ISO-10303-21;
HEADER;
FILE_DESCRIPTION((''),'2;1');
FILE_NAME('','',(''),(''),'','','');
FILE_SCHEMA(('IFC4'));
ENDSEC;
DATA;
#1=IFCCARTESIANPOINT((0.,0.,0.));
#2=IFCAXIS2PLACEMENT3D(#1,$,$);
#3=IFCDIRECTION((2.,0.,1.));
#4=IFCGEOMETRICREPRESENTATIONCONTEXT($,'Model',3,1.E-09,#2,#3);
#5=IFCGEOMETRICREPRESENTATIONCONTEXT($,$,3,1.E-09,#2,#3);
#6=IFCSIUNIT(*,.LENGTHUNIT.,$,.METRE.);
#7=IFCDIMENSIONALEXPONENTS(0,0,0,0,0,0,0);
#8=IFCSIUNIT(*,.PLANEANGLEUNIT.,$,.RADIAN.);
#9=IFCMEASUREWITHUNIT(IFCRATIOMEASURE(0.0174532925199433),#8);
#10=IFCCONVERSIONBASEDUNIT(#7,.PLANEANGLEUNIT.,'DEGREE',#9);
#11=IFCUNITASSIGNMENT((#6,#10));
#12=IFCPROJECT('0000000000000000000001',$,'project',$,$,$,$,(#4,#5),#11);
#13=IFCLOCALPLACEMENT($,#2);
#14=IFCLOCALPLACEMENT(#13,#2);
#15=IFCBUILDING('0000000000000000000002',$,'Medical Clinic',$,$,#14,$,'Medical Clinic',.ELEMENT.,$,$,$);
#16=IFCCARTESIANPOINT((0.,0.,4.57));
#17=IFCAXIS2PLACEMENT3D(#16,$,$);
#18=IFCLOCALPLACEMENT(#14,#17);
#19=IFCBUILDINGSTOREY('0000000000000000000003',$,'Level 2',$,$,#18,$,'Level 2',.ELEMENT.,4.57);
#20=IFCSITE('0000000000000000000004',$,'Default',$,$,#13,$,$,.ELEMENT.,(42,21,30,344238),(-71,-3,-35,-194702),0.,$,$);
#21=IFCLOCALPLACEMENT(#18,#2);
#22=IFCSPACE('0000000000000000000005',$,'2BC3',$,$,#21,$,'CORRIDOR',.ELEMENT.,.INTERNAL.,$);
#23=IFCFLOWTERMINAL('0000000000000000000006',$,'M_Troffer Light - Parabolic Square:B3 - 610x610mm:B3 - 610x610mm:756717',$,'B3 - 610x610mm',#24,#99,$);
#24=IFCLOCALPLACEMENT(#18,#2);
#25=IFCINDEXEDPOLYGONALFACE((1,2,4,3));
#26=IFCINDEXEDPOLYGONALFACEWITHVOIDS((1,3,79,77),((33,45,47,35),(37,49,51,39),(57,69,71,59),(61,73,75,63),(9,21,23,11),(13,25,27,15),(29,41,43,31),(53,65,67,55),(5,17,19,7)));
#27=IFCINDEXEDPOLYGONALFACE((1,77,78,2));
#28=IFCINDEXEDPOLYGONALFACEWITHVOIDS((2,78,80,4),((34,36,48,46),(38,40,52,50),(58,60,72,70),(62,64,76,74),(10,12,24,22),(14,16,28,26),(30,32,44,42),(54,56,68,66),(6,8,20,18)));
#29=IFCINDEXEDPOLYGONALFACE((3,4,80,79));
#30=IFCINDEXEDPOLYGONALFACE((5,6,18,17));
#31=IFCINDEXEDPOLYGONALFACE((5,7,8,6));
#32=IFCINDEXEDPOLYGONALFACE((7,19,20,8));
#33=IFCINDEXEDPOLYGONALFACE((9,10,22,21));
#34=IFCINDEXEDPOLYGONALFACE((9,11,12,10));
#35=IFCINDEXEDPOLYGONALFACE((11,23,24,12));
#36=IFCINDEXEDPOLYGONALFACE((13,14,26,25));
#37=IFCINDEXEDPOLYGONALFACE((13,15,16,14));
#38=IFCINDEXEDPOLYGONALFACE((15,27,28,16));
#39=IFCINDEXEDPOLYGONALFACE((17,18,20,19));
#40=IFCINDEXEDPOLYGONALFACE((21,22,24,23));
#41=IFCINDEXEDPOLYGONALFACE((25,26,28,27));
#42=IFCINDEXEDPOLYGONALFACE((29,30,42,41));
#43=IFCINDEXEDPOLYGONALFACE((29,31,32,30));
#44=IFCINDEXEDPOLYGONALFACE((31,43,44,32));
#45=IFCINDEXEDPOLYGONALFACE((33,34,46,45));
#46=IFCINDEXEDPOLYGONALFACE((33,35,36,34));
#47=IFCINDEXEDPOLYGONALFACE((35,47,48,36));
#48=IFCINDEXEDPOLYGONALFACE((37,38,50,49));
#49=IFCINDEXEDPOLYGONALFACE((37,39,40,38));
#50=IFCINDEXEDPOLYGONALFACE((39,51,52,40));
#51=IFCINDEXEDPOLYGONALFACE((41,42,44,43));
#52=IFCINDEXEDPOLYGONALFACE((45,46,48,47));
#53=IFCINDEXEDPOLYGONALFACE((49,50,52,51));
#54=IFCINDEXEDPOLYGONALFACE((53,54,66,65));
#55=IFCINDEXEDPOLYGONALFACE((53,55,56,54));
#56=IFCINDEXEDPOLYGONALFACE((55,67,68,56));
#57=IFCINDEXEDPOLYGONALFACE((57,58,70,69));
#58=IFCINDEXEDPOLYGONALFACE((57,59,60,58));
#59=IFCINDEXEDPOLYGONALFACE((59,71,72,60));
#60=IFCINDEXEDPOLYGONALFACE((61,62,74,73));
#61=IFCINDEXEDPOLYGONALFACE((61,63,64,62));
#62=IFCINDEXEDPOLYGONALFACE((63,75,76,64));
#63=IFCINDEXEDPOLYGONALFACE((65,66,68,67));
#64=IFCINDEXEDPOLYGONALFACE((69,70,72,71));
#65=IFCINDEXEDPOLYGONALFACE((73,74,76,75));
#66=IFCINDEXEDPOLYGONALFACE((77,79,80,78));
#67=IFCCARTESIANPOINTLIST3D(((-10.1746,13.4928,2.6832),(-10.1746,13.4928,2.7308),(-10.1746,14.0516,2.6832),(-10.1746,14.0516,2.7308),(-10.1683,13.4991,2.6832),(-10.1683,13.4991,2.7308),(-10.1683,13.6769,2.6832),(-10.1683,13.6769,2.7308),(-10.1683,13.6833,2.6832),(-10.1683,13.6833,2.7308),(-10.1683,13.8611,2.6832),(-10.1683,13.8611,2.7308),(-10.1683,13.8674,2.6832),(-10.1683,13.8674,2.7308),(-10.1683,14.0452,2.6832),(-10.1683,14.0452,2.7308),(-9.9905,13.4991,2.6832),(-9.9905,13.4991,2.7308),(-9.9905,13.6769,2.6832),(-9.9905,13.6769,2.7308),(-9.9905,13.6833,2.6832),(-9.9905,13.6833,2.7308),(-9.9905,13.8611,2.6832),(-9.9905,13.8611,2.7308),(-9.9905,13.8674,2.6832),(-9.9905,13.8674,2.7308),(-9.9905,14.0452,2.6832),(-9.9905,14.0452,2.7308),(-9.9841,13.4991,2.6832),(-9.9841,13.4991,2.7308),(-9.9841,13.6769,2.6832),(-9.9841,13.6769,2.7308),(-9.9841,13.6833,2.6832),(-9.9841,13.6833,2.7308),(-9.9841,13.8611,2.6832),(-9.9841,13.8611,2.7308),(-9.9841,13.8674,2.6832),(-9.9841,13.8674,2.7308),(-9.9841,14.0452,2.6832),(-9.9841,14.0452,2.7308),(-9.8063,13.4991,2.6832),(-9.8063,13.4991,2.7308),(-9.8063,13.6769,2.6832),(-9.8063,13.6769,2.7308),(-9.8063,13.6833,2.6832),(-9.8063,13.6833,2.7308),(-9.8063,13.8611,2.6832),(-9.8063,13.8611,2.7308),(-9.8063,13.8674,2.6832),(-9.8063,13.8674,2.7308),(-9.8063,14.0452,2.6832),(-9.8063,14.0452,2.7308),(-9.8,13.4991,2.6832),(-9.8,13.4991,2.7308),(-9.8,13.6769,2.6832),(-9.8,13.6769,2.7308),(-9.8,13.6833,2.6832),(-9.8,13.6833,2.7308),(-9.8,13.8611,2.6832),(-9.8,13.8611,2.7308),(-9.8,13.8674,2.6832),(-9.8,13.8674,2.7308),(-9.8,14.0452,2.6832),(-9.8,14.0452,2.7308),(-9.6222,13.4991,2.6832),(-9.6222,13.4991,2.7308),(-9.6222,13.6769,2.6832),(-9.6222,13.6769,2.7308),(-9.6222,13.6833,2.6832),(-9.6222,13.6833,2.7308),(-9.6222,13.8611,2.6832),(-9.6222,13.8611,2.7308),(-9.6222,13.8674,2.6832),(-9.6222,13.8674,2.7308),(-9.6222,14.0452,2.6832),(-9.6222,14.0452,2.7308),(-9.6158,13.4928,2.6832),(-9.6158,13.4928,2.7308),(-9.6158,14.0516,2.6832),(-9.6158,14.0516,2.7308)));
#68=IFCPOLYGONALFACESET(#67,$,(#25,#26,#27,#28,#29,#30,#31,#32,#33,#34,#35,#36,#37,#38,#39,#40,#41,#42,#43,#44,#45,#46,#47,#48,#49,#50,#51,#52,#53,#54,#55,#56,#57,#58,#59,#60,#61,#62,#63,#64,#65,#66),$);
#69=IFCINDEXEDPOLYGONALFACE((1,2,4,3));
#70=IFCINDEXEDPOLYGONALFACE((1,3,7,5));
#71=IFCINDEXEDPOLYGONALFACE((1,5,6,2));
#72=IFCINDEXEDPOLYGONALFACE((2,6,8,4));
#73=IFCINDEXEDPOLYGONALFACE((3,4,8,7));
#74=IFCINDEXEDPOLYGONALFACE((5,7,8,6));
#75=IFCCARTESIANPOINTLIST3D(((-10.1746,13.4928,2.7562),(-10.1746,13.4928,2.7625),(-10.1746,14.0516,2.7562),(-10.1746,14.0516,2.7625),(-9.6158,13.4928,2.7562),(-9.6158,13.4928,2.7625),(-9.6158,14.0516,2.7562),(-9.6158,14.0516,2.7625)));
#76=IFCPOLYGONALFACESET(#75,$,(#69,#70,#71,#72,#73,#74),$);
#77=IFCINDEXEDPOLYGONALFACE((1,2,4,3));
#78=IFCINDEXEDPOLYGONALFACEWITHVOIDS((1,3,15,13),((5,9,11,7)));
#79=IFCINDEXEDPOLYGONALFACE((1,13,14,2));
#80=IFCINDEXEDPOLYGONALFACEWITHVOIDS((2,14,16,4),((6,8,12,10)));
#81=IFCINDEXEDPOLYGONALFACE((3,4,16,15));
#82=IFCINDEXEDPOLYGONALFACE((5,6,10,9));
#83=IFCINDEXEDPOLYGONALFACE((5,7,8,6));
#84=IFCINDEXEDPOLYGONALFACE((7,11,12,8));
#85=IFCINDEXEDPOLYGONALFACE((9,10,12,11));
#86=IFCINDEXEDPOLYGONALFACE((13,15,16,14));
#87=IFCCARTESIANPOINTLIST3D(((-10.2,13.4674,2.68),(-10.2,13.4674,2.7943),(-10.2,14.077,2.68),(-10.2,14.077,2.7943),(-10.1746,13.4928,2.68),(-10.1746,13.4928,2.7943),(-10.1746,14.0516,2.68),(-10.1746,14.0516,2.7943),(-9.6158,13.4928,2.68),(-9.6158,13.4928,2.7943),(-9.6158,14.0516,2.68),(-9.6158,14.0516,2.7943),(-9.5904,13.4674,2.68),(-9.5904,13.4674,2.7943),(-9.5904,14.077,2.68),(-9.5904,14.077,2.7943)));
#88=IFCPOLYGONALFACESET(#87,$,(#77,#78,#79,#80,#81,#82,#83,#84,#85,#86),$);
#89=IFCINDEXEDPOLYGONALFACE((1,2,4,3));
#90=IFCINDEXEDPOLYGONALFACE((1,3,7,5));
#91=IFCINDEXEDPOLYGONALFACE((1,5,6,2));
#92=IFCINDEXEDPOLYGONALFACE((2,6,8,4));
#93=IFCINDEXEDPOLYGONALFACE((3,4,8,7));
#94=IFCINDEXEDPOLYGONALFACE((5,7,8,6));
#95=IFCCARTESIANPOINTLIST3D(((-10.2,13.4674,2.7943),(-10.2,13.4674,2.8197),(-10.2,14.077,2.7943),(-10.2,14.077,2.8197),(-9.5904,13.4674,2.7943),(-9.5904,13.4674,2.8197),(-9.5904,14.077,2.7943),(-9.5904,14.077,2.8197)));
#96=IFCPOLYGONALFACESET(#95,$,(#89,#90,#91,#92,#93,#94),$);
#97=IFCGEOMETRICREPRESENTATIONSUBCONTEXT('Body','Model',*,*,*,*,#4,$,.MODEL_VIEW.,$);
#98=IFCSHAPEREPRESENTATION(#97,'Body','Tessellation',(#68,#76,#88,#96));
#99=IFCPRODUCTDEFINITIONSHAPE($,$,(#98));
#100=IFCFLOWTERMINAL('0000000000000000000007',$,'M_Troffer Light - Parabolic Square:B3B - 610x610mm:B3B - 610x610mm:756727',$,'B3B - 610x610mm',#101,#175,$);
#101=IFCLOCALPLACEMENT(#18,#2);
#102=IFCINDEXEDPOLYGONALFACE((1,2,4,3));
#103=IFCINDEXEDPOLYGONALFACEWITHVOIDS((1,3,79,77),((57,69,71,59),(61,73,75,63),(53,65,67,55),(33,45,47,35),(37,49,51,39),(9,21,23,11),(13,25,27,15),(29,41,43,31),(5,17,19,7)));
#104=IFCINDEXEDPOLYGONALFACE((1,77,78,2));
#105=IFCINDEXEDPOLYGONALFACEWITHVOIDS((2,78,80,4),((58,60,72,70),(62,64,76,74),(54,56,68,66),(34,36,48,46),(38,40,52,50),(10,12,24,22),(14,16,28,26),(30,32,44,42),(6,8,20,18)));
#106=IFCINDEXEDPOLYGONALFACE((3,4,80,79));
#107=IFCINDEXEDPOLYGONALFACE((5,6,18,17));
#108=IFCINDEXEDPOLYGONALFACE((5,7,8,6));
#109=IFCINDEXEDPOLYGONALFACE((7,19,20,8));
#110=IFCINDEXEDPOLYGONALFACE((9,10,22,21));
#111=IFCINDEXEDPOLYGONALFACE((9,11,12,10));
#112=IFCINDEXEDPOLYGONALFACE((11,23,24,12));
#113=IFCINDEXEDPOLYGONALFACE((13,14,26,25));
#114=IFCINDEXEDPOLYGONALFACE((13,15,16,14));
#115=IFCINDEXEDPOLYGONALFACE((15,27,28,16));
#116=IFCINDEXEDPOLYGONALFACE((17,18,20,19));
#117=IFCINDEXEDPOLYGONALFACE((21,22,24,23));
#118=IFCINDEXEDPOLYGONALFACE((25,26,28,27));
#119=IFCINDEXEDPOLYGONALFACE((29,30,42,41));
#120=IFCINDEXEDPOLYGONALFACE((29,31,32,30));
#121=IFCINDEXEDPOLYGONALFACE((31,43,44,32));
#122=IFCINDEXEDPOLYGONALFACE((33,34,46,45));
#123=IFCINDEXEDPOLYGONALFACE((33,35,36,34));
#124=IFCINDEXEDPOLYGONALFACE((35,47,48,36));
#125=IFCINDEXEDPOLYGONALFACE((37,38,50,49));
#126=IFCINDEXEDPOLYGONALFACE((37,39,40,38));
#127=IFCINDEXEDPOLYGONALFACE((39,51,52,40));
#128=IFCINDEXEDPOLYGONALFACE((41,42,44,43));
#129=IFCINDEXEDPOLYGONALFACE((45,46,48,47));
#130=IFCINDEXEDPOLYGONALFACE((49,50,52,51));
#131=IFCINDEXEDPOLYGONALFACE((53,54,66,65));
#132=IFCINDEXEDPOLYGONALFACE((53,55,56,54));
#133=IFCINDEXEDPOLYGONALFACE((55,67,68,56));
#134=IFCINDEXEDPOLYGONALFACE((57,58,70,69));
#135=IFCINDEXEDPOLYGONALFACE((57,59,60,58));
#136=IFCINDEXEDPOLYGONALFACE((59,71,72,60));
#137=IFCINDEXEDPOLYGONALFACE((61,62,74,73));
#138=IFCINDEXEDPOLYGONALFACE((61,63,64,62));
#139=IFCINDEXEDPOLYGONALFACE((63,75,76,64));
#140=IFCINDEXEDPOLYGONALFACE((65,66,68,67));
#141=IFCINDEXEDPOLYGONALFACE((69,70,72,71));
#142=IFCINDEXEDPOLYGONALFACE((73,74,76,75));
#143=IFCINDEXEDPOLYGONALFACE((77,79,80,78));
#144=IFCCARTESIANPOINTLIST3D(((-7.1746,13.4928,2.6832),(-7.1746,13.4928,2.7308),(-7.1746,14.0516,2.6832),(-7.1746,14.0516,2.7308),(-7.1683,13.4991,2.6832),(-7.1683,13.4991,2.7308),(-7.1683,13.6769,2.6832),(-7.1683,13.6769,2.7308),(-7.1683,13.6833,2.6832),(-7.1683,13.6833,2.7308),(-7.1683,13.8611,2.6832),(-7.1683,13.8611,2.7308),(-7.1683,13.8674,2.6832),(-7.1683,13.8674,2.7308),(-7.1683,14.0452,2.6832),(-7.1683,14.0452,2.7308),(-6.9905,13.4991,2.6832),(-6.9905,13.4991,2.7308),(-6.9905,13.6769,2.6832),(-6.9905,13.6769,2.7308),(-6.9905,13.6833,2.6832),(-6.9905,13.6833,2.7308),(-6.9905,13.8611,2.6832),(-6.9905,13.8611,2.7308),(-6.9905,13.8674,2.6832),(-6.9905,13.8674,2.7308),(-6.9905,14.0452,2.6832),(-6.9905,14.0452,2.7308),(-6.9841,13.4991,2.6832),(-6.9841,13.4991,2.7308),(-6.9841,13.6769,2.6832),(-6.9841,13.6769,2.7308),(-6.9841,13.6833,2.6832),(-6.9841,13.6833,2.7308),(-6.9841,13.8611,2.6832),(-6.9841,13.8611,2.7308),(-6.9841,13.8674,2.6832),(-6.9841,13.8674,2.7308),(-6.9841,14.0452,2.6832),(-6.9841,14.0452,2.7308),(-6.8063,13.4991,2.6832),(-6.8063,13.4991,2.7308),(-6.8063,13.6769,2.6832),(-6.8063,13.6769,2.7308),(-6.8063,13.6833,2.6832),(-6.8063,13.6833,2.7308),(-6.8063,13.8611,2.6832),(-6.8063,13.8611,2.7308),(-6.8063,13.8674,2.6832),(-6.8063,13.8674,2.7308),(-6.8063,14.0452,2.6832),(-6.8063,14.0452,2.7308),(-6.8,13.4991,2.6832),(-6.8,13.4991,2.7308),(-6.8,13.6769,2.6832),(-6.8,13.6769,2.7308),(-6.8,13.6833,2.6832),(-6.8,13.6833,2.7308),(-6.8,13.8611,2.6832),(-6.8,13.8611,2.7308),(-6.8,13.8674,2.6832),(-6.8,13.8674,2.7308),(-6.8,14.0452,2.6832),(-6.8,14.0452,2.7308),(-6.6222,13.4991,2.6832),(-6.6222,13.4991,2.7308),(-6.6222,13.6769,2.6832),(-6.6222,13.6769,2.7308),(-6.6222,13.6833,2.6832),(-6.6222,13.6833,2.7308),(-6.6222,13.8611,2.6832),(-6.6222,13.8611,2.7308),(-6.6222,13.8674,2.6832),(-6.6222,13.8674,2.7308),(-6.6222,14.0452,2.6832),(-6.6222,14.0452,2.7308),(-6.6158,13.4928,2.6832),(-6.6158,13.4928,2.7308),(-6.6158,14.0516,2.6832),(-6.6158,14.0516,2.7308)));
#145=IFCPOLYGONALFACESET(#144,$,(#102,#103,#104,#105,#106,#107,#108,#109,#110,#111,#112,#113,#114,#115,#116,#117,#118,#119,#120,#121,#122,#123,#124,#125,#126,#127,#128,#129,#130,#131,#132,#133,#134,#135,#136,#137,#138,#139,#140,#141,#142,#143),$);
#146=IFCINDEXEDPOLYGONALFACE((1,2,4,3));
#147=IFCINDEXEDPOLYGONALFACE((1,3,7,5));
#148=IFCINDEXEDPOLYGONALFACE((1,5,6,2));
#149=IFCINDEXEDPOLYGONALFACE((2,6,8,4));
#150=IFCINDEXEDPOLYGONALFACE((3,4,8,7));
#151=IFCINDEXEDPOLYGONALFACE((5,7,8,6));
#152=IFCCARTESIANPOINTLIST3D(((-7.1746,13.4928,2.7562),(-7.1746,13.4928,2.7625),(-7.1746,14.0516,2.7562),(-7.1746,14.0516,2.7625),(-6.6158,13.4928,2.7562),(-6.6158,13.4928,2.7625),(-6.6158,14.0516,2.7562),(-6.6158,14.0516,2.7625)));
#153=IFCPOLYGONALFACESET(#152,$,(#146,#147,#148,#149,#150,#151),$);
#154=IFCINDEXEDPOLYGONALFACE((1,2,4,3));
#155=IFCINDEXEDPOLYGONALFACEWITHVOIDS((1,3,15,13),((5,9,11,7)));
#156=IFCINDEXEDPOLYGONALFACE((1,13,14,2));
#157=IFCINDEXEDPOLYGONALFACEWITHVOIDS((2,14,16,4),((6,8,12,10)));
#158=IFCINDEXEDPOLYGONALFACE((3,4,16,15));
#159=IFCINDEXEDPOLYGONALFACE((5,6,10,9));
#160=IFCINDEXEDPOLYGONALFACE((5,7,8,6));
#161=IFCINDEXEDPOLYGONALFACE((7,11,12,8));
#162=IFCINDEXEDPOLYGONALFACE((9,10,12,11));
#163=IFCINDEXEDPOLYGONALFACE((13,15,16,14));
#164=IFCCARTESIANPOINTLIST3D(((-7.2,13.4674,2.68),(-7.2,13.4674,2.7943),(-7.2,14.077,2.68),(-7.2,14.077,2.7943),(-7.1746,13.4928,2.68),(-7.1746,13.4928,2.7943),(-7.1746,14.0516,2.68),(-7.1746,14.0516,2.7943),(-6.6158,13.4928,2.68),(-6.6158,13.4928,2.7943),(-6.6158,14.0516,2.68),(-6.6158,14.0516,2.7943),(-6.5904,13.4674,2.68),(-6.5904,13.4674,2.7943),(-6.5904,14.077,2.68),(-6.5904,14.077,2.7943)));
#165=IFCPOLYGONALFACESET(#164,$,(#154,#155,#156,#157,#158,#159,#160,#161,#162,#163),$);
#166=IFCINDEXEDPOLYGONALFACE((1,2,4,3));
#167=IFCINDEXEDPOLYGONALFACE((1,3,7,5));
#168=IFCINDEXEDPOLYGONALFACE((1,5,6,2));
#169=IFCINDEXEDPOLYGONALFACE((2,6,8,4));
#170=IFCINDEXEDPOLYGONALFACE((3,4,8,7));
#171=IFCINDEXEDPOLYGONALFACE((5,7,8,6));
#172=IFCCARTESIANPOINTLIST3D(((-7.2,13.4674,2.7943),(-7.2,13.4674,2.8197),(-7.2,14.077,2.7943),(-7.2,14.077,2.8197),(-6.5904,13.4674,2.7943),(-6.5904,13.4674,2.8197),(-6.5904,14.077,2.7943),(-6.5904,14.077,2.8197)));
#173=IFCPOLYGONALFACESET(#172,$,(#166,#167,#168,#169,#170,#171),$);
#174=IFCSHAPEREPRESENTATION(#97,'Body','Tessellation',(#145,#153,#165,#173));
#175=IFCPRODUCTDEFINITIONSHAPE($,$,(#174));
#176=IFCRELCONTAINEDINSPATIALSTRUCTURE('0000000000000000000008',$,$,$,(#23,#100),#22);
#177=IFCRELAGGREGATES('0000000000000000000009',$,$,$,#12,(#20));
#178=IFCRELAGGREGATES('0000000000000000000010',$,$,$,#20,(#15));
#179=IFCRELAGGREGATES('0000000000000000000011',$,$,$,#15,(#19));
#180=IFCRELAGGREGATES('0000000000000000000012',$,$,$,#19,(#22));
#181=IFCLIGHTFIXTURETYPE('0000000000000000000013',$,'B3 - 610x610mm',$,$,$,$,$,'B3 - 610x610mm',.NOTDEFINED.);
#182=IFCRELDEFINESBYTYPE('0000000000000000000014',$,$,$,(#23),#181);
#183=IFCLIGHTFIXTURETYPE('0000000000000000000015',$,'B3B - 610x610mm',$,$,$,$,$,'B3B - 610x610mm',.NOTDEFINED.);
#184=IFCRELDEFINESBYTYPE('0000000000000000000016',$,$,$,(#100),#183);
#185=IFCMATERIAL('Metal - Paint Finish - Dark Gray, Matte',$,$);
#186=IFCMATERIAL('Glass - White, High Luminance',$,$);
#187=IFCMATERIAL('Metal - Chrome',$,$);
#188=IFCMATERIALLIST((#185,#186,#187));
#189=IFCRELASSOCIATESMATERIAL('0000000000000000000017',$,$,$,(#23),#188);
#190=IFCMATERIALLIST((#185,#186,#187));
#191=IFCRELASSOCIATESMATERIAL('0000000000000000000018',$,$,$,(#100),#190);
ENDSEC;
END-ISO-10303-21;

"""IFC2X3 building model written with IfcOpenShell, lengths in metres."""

from ifc_helpers import new_model, entity, si_unit, converted_unit, direction, frame, origin, origin_2d_with_axis, place, context, subcontext, project, spatial, polyline, rectangle, outline, extrude, source, transform, mapped, material, material_list, type_object, type_shapes, element, save


model = new_model("IFC2X3")

# Units and contexts
model_context = context("Model", 3, precision=1e-09, world=origin(), true_north=direction((2.0, 0.0, 1.0)))
context_of_model = context(None, 3, precision=1e-09, world=origin(), true_north=direction((2.0, 0.0, 1.0)))
body_context = subcontext(model_context, "Body", "Model", "MODEL_VIEW")
ifc_project = project(units=[si_unit("LENGTHUNIT", "METRE"), converted_unit("PLANEANGLEUNIT", "DEGREE", entity("IfcRatioMeasure", 0.0174532925199433), si_unit("PLANEANGLEUNIT", "RADIAN"), dimensions=[0, 0, 0, 0, 0, 0, 0])], contexts=[model_context, context_of_model])

# Site, building, storey, space
site_placement = place(None, origin())
site = spatial("IfcSite", under=ifc_project, at=site_placement, Name="Default", CompositionType="ELEMENT", RefLatitude=(42, 21, 30, 344238), RefLongitude=(-71, -3, -35, -194702), RefElevation=0.0)
building_placement = place(site_placement, origin())
building = spatial("IfcBuilding", under=site, at=building_placement, Name="Medical Clinic", LongName="Medical Clinic", CompositionType="ELEMENT")
storey_placement = place(building_placement, frame((0.0, 0.0, 4.57)))
storey = spatial("IfcBuildingStorey", under=building, at=storey_placement, Name="Level 2", LongName="Level 2", CompositionType="ELEMENT", Elevation=4.57)
space_1_placement = place(storey_placement, origin())
space_1 = spatial("IfcSpace", under=storey, at=space_1_placement, Name="2BC3", LongName="CORRIDOR", CompositionType="ELEMENT", InteriorOrExteriorSpace="INTERNAL")

# Flow terminals
ifc_material_1 = material(Name="Metal - Paint Finish - Dark Gray, Matte")
ifc_material_2 = material(Name="Glass - White, High Luminance")
ifc_material_3 = material(Name="Metal - Chrome")
ifc_material_list_1 = material_list([ifc_material_1, ifc_material_2, ifc_material_3])
light_fixture_type_1 = type_object("IfcLightFixtureType", Name="B3 - 610x610mm", ElementType="B3 - 610x610mm", PredefinedType="NOTDEFINED")
shared_shape_1 = source(origin(), body_context, "Body", "SweptSolid", [
    extrude(outline(polyline([(-0.2794, -0.2794), (0.2794, -0.2794), (0.2794, 0.2794), (-0.2794, 0.2794), (-0.2794, -0.2794)]), holes=[polyline([(-0.0952, 0.0953), (-0.273, 0.0953), (-0.273, 0.2731), (-0.0952, 0.2731), (-0.0952, 0.0953)]), polyline([(0.2731, 0.0953), (0.0953, 0.0953), (0.0953, 0.2731), (0.2731, 0.2731), (0.2731, 0.0953)]), polyline([(-0.0889, 0.2731), (0.0889, 0.2731), (0.0889, 0.0953), (-0.0889, 0.0953), (-0.0889, 0.2731)]), polyline([(0.2731, -0.273), (0.0953, -0.273), (0.0953, -0.0952), (0.2731, -0.0952), (0.2731, -0.273)]), polyline([(0.0889, -0.273), (-0.0889, -0.273), (-0.0889, -0.0952), (0.0889, -0.0952), (0.0889, -0.273)]), polyline([(-0.0952, -0.273), (-0.273, -0.273), (-0.273, -0.0952), (-0.0952, -0.0952), (-0.0952, -0.273)]), polyline([(-0.0952, -0.0889), (-0.273, -0.0889), (-0.273, 0.0889), (-0.0952, 0.0889), (-0.0952, -0.0889)]), polyline([(0.0889, -0.0889), (-0.0889, -0.0889), (-0.0889, 0.0889), (0.0889, 0.0889), (0.0889, -0.0889)]), polyline([(0.2731, -0.0889), (0.0953, -0.0889), (0.0953, 0.0889), (0.2731, 0.0889), (0.2731, -0.0889)])]), frame((0.0, -0.3048, -0.0508), z_axis=(0.0, 0.0, 1.0), x_axis=(-1.0, 0.0, 0.0)), (0.0, 0.0, 1.0), 0.0476),
    extrude(rectangle(XDim=0.5588, YDim=0.5588, at=origin_2d_with_axis()), frame((0.0, -0.3048, -0.0825), z_axis=(0.0, 0.0, 1.0), x_axis=(-1.0, 0.0, 0.0)), (0.0, 0.0, 1.0), 0.0064),
    extrude(outline(polyline([(-0.3048, -0.3048), (0.3048, -0.3048), (0.3048, 0.3048), (-0.3048, 0.3048), (-0.3048, -0.3048)]), holes=[polyline([(0.2794, 0.2794), (0.2794, -0.2794), (-0.2794, -0.2794), (-0.2794, 0.2794), (0.2794, 0.2794)])]), frame((0.0, -0.3048, -0.1143)), (0.0, 0.0, 1.0), 0.1143),
    extrude(rectangle(XDim=0.6096, YDim=0.6096, at=origin_2d_with_axis()), frame((0.0, -0.3048, -0.1397), z_axis=(0.0, 0.0, 1.0), x_axis=(-1.0, 0.0, 0.0)), (0.0, 0.0, 1.0), 0.0254),
])
type_shapes(light_fixture_type_1, [shared_shape_1])
flow_terminal_1_placement = place(space_1_placement, frame((-9.8952, 13.4674, 2.68), z_axis=(0.0, 0.0, -1.0), x_axis=(1.0, 0.0, 0.0)))
element("IfcFlowTerminal", 1, at=flow_terminal_1_placement, inside=space_1, type_object=light_fixture_type_1, material=ifc_material_list_1, Name="M_Troffer Light - Parabolic Square:B3 - 610x610mm:B3 - 610x610mm:756717", ObjectType="B3 - 610x610mm", context=body_context, shape_type="MappedRepresentation", body=[
    mapped(shared_shape_1, transform((0.0, 0.0, 0.0), scale=1.0)),
])
ifc_material_list_2 = material_list([ifc_material_1, ifc_material_2, ifc_material_3])
light_fixture_type_2 = type_object("IfcLightFixtureType", Name="B3B - 610x610mm", ElementType="B3B - 610x610mm", PredefinedType="NOTDEFINED")
shared_shape_2 = source(origin(), body_context, "Body", "SweptSolid", [
    extrude(outline(polyline([(-0.2794, -0.2794), (0.2794, -0.2794), (0.2794, 0.2794), (-0.2794, 0.2794), (-0.2794, -0.2794)]), holes=[polyline([(-0.0952, 0.0953), (-0.273, 0.0953), (-0.273, 0.2731), (-0.0952, 0.2731), (-0.0952, 0.0953)]), polyline([(0.2731, 0.0953), (0.0953, 0.0953), (0.0953, 0.2731), (0.2731, 0.2731), (0.2731, 0.0953)]), polyline([(-0.0889, 0.2731), (0.0889, 0.2731), (0.0889, 0.0953), (-0.0889, 0.0953), (-0.0889, 0.2731)]), polyline([(0.2731, -0.273), (0.0953, -0.273), (0.0953, -0.0952), (0.2731, -0.0952), (0.2731, -0.273)]), polyline([(0.0889, -0.273), (-0.0889, -0.273), (-0.0889, -0.0952), (0.0889, -0.0952), (0.0889, -0.273)]), polyline([(-0.0952, -0.273), (-0.273, -0.273), (-0.273, -0.0952), (-0.0952, -0.0952), (-0.0952, -0.273)]), polyline([(-0.0952, -0.0889), (-0.273, -0.0889), (-0.273, 0.0889), (-0.0952, 0.0889), (-0.0952, -0.0889)]), polyline([(0.0889, -0.0889), (-0.0889, -0.0889), (-0.0889, 0.0889), (0.0889, 0.0889), (0.0889, -0.0889)]), polyline([(0.2731, -0.0889), (0.0953, -0.0889), (0.0953, 0.0889), (0.2731, 0.0889), (0.2731, -0.0889)])]), frame((0.0, -0.3048, -0.0508), z_axis=(0.0, 0.0, 1.0), x_axis=(-1.0, 0.0, 0.0)), (0.0, 0.0, 1.0), 0.0476),
    extrude(rectangle(XDim=0.5588, YDim=0.5588, at=origin_2d_with_axis()), frame((0.0, -0.3048, -0.0825), z_axis=(0.0, 0.0, 1.0), x_axis=(-1.0, 0.0, 0.0)), (0.0, 0.0, 1.0), 0.0064),
    extrude(outline(polyline([(-0.3048, -0.3048), (0.3048, -0.3048), (0.3048, 0.3048), (-0.3048, 0.3048), (-0.3048, -0.3048)]), holes=[polyline([(0.2794, 0.2794), (0.2794, -0.2794), (-0.2794, -0.2794), (-0.2794, 0.2794), (0.2794, 0.2794)])]), frame((0.0, -0.3048, -0.1143)), (0.0, 0.0, 1.0), 0.1143),
    extrude(rectangle(XDim=0.6096, YDim=0.6096, at=origin_2d_with_axis()), frame((0.0, -0.3048, -0.1397), z_axis=(0.0, 0.0, 1.0), x_axis=(-1.0, 0.0, 0.0)), (0.0, 0.0, 1.0), 0.0254),
])
type_shapes(light_fixture_type_2, [shared_shape_2])
flow_terminal_2_placement = place(space_1_placement, frame((-6.8952, 13.4674, 2.68), z_axis=(0.0, 0.0, -1.0), x_axis=(1.0, 0.0, 0.0)))
element("IfcFlowTerminal", 2, at=flow_terminal_2_placement, inside=space_1, type_object=light_fixture_type_2, material=ifc_material_list_2, Name="M_Troffer Light - Parabolic Square:B3B - 610x610mm:B3B - 610x610mm:756727", ObjectType="B3B - 610x610mm", context=body_context, shape_type="MappedRepresentation", body=[
    mapped(shared_shape_2, transform((0.0, 0.0, 0.0), scale=1.0)),
])

save(model, "model.ifc")
